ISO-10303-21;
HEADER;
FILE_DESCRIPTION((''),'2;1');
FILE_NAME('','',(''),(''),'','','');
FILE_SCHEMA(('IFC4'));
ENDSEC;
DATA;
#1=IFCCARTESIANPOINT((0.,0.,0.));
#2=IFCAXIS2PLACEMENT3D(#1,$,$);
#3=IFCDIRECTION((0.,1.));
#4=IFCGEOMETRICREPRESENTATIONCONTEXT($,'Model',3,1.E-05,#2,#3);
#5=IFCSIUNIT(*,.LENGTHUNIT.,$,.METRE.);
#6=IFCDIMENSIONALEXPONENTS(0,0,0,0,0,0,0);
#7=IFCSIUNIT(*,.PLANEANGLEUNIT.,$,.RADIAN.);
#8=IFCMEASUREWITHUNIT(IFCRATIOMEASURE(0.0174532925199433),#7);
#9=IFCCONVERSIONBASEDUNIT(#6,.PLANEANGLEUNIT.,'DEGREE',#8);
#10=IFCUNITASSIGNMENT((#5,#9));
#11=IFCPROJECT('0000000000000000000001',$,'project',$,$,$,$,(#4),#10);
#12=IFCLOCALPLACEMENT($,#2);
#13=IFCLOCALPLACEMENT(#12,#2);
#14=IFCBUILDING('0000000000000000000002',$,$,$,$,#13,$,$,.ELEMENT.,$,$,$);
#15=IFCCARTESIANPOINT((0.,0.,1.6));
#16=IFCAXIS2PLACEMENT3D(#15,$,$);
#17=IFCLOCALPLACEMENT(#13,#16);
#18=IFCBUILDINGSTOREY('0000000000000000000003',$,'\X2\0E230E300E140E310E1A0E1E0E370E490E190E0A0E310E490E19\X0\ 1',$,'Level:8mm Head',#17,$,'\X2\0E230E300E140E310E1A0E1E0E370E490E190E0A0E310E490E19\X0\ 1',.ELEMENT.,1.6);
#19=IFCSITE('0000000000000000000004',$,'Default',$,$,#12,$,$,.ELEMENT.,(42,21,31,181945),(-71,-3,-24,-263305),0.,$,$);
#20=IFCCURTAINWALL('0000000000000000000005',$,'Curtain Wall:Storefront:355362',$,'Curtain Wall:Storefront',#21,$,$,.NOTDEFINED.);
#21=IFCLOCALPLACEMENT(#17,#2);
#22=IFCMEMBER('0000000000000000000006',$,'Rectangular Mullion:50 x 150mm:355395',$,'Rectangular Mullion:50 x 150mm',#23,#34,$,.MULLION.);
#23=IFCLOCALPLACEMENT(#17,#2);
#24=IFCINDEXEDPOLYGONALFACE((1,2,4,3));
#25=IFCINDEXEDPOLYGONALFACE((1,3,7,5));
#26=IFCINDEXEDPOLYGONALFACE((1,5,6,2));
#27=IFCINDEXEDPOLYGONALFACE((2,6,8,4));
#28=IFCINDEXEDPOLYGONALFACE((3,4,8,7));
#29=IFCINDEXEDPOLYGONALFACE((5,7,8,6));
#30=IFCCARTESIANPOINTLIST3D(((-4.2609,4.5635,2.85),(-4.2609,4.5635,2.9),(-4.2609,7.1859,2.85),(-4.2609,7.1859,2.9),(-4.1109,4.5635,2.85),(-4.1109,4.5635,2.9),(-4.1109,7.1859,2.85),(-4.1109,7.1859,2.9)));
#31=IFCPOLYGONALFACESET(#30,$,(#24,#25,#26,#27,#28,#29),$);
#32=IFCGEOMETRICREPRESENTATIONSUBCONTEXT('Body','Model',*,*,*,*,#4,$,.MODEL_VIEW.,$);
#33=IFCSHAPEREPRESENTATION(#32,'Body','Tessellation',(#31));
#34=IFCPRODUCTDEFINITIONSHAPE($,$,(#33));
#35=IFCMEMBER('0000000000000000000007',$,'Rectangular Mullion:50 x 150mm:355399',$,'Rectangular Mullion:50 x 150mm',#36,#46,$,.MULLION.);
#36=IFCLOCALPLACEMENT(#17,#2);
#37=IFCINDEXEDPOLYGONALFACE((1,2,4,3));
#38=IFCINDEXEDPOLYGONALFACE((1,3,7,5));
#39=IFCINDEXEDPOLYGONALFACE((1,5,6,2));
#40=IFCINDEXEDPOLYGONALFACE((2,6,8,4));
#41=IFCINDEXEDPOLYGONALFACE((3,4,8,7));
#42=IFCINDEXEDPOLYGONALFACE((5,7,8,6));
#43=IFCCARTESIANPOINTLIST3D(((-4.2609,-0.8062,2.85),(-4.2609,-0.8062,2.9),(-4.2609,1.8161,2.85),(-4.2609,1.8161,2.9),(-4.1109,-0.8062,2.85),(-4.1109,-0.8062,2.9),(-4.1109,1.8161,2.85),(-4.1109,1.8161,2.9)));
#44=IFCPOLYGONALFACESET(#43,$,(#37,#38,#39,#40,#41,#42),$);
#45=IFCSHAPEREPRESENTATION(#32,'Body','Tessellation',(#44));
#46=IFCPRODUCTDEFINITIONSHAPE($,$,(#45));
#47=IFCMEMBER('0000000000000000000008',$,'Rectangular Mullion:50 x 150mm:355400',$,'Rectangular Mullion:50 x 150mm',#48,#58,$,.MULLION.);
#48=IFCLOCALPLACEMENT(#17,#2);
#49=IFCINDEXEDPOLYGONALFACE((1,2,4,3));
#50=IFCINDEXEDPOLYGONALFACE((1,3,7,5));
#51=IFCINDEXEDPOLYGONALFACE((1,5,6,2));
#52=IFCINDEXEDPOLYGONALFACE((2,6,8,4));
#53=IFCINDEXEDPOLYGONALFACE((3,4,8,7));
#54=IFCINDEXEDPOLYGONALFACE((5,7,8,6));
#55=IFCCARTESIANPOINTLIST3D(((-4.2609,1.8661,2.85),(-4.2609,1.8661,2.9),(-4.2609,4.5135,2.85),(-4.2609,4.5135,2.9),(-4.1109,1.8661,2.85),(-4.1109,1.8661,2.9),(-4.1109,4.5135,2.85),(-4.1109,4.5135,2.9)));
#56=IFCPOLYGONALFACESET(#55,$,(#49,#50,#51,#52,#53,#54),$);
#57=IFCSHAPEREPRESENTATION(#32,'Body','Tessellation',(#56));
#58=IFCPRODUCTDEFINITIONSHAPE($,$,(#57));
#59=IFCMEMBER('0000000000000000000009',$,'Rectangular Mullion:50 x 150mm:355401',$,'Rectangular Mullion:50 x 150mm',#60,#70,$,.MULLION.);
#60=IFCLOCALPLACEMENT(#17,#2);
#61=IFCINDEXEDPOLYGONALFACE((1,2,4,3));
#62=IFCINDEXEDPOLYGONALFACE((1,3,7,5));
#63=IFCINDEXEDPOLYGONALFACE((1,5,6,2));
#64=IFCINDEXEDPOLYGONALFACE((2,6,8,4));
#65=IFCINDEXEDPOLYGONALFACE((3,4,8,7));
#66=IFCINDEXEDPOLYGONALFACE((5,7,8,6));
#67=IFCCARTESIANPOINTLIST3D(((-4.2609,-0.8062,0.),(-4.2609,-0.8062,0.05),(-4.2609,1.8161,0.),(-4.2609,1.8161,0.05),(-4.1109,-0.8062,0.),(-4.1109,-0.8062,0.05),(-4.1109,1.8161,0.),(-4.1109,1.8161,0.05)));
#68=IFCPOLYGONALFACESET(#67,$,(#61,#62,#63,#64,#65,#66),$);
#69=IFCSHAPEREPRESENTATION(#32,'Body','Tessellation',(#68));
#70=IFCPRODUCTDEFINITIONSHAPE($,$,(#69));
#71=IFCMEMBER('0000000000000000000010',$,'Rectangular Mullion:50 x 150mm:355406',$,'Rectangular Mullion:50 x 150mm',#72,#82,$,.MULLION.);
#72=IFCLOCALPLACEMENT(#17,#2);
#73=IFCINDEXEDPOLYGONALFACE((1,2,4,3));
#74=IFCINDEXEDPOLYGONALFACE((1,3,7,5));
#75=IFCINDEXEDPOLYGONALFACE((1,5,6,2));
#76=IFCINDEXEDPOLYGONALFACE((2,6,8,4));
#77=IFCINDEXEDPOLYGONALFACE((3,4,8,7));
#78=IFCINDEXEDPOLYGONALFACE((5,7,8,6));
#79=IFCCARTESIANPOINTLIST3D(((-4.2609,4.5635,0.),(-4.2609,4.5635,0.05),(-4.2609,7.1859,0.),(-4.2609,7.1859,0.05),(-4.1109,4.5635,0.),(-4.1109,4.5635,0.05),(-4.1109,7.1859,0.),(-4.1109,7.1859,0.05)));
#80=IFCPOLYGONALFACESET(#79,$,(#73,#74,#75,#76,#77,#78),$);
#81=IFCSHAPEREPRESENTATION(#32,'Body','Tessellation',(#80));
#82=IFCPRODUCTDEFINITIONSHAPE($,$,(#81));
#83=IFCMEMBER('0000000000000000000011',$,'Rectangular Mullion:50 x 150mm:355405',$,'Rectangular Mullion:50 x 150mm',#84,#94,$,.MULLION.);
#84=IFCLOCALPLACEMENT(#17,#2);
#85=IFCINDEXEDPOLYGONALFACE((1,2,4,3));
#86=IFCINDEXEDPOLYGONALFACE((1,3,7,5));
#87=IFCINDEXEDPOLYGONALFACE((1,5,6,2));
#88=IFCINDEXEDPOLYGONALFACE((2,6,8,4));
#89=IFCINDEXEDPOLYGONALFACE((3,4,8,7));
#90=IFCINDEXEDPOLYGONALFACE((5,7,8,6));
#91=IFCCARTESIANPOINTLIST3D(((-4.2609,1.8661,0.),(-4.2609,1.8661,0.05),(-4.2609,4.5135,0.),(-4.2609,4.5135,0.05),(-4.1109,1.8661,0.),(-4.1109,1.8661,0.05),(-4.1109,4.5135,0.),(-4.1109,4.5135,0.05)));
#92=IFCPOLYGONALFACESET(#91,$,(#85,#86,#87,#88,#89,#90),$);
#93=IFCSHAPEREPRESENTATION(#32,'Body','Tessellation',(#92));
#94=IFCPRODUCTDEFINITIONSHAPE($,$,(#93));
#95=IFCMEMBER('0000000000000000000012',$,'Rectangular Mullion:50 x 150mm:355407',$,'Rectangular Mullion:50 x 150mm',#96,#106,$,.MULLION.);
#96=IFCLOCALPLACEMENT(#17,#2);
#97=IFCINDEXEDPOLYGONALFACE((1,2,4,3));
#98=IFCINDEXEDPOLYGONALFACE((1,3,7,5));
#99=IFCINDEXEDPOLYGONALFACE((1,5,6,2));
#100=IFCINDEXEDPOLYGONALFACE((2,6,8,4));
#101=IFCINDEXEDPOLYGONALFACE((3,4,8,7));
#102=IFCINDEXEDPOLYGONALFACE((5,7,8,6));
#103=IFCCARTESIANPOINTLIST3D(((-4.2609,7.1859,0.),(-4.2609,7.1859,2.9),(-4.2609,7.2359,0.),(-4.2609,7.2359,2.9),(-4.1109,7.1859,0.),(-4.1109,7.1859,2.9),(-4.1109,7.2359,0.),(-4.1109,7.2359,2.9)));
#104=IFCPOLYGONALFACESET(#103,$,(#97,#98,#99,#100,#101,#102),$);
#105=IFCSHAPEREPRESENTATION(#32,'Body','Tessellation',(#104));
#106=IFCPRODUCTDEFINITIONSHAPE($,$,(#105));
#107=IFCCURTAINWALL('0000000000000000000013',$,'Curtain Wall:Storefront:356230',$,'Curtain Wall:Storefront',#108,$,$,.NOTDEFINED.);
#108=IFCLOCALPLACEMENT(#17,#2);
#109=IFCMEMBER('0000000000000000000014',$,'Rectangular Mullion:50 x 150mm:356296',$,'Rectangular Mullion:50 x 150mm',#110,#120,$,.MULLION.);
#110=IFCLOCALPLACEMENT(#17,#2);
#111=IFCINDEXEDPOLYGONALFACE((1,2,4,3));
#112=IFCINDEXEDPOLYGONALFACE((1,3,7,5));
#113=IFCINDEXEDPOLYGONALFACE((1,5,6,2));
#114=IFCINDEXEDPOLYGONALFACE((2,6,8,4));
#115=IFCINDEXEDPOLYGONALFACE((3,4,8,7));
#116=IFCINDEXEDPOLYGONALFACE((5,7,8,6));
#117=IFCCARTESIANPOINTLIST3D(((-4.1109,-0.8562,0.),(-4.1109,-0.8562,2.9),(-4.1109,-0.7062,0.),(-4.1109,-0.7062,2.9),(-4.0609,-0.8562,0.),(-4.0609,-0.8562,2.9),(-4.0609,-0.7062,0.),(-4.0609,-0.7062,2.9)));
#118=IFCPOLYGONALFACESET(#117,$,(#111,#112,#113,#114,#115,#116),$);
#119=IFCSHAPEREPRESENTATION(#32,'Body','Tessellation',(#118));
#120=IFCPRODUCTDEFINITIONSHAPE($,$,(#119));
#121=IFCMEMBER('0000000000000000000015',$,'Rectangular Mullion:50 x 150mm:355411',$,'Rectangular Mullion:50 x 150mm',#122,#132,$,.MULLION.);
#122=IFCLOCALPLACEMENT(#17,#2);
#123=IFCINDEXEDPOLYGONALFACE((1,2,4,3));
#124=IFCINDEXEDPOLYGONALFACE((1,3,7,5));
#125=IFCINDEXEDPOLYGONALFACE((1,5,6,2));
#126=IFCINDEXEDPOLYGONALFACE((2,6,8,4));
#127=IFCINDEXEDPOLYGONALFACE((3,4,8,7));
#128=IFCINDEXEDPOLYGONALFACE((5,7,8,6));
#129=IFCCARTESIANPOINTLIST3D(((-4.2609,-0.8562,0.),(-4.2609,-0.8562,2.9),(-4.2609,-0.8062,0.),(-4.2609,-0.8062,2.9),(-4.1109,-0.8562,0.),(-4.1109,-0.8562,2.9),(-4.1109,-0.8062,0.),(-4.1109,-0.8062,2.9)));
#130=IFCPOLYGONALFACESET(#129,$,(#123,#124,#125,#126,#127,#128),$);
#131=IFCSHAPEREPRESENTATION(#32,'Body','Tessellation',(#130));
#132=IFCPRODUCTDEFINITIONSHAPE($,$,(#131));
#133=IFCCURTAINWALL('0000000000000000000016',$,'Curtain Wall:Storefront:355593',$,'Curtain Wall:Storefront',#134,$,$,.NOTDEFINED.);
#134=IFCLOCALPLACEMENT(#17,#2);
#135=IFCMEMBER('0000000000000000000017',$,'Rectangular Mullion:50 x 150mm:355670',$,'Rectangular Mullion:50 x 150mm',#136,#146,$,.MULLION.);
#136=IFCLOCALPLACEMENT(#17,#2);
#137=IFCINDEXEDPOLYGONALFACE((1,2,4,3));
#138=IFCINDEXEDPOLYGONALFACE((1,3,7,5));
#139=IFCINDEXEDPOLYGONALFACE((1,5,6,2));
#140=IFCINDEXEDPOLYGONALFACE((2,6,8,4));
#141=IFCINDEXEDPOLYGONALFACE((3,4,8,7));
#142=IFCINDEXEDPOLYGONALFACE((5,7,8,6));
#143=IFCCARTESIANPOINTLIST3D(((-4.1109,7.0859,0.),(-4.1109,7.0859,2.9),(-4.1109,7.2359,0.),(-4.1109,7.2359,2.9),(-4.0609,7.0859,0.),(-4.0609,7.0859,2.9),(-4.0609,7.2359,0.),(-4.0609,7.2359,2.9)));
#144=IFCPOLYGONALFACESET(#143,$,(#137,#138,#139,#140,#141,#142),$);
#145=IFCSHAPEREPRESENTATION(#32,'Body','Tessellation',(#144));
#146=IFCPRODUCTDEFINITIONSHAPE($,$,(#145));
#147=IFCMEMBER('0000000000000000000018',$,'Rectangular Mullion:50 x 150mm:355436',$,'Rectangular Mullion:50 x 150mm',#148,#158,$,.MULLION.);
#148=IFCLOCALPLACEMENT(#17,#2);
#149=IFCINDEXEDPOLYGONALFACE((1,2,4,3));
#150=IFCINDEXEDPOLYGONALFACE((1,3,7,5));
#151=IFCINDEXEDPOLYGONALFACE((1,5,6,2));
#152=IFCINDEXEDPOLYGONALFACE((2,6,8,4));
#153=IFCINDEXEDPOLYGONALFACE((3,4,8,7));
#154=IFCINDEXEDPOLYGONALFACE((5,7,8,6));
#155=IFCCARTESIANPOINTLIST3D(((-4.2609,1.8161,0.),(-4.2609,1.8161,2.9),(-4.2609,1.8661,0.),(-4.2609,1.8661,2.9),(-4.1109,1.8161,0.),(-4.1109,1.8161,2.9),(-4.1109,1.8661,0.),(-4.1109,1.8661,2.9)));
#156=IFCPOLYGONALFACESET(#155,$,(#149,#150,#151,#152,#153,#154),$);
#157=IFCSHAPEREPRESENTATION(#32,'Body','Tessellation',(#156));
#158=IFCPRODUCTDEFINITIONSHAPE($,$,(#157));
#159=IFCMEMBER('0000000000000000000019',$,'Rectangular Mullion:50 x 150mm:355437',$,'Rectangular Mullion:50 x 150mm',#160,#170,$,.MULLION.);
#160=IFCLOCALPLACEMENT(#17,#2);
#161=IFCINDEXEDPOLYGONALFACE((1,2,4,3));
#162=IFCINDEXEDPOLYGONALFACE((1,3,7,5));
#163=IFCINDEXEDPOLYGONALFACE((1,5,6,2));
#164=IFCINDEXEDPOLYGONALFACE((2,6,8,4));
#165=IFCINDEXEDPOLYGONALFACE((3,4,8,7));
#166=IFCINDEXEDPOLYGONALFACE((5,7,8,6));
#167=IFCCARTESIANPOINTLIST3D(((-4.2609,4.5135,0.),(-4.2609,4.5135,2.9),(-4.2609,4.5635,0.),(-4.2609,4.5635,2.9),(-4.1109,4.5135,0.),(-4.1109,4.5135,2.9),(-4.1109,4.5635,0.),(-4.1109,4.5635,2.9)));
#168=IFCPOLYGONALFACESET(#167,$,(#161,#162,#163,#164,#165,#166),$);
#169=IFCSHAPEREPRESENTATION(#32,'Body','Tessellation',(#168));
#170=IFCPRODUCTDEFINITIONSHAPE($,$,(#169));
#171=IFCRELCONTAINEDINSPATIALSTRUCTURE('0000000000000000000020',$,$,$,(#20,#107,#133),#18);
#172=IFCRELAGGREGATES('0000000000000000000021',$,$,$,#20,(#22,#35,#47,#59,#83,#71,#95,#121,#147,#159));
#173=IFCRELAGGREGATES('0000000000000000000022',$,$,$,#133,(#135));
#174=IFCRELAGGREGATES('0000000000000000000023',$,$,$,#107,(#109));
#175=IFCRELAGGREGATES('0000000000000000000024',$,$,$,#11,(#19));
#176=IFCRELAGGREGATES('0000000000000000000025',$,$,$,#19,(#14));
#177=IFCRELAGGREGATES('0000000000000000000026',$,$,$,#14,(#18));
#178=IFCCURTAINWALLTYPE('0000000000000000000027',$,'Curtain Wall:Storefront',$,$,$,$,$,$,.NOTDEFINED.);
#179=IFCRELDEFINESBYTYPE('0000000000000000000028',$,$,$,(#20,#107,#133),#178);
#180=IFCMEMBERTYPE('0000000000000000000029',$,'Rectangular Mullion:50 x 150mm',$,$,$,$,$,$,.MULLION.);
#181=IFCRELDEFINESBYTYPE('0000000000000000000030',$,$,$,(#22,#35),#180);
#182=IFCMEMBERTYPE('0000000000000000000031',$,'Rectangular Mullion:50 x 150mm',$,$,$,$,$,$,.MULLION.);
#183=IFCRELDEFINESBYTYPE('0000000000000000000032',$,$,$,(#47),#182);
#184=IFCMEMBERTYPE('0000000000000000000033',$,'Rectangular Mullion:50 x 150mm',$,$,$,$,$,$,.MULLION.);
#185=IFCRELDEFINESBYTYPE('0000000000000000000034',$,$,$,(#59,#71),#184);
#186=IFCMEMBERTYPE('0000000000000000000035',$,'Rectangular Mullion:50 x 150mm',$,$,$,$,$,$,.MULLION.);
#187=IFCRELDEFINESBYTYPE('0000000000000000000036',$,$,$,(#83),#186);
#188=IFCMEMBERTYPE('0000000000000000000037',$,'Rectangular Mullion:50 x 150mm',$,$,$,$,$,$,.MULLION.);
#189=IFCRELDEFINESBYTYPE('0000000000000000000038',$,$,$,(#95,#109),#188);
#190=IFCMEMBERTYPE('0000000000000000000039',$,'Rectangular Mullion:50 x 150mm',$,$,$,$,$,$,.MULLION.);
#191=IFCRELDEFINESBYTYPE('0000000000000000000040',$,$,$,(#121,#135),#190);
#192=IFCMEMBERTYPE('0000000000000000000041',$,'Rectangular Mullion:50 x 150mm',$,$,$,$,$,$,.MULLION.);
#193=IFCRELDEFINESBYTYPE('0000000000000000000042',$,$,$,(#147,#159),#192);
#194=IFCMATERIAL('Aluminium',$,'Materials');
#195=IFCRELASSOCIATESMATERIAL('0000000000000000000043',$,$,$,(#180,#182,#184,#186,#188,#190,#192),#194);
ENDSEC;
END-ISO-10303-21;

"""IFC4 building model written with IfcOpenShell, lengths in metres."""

from ifc_helpers import new_model, entity, si_unit, converted_unit, direction, frame, origin, place, context, subcontext, project, spatial, indexed_curve, outline, extrude, source, transform, mapped, material, type_object, type_shapes, element, aggregate, save


model = new_model("IFC4")

# Units and contexts
model_context = context("Model", 3, precision=1e-05, world=origin(), true_north=direction((0.0, 1.0)))
body_context = subcontext(model_context, "Body", "Model", "MODEL_VIEW")
ifc_project = project(units=[si_unit("LENGTHUNIT", "METRE"), converted_unit("PLANEANGLEUNIT", "DEGREE", entity("IfcRatioMeasure", 0.0174532925199433), si_unit("PLANEANGLEUNIT", "RADIAN"), dimensions=[0, 0, 0, 0, 0, 0, 0])], contexts=[model_context])

# Site, building, storey
site_placement = place(None, origin())
site = spatial("IfcSite", under=ifc_project, at=site_placement, Name="Default", CompositionType="ELEMENT", RefLatitude=(42, 21, 31, 181945), RefLongitude=(-71, -3, -24, -263305), RefElevation=0.0)
building_placement = place(site_placement, origin())
building = spatial("IfcBuilding", under=site, at=building_placement, CompositionType="ELEMENT")
storey_placement = place(building_placement, frame((0.0, 0.0, 1.6)))
storey = spatial("IfcBuildingStorey", under=building, at=storey_placement, Name="ระดับพื้นชั้น 1", ObjectType="Level:8mm Head", LongName="ระดับพื้นชั้น 1", CompositionType="ELEMENT", Elevation=1.6)

# Curtain wall, members
curtain_wall_type = type_object("IfcCurtainWallType", Name="Curtain Wall:Storefront", PredefinedType="NOTDEFINED")
curtain_wall_1_placement = place(storey_placement, frame((0.0, 0.0, -1.6)))
curtain_wall_1 = element("IfcCurtainWall", 1, at=curtain_wall_1_placement, inside=storey, type_object=curtain_wall_type, Name="Curtain Wall:Storefront:355362", ObjectType="Curtain Wall:Storefront", PredefinedType="NOTDEFINED")
ifc_material_1 = material(Name="Aluminium", Category="Materials")
member_type_1 = type_object("IfcMemberType", Name="Rectangular Mullion:50 x 150mm", PredefinedType="MULLION", material=ifc_material_1)
shared_shape_1 = source(origin(), body_context, "Body", "SweptSolid", [
    extrude(outline(indexed_curve([(-0.075, -0.025), (0.075, -0.025), (0.075, 0.025), (-0.075, 0.025), (-0.075, -0.025)], self_intersect=False)), frame((-0.025, 0.0, -2.6224), z_axis=(0.0, 0.0, 1.0), x_axis=(0.0, -1.0, 0.0)), (0.0, 0.0, 1.0), 2.6224),
])
type_shapes(member_type_1, [shared_shape_1])
member_1_placement = place(curtain_wall_1_placement, frame((-4.1859, 7.1859, 4.5), z_axis=(0.0, 1.0, 0.0), x_axis=(0.0, 0.0, 1.0)))
member_1 = element("IfcMember", 2, at=member_1_placement, type_object=member_type_1, Name="Rectangular Mullion:50 x 150mm:355395", ObjectType="Rectangular Mullion:50 x 150mm", PredefinedType="MULLION", context=body_context, shape_type="MappedRepresentation", body=[
    mapped(shared_shape_1, transform((0.0, 0.0, 0.0), scale=1.0)),
])
member_2_placement = place(curtain_wall_1_placement, frame((-4.1859, 1.8161, 4.5), z_axis=(0.0, 1.0, 0.0), x_axis=(0.0, 0.0, 1.0)))
member_2 = element("IfcMember", 3, at=member_2_placement, type_object=member_type_1, Name="Rectangular Mullion:50 x 150mm:355399", ObjectType="Rectangular Mullion:50 x 150mm", PredefinedType="MULLION", context=body_context, shape_type="MappedRepresentation", body=[
    mapped(shared_shape_1, transform((0.0, 0.0, 0.0), scale=1.0)),
])
member_type_2 = type_object("IfcMemberType", Name="Rectangular Mullion:50 x 150mm", PredefinedType="MULLION", material=ifc_material_1)
shared_shape_2 = source(origin(), body_context, "Body", "SweptSolid", [
    extrude(outline(indexed_curve([(-0.075, -0.025), (0.075, -0.025), (0.075, 0.025), (-0.075, 0.025), (-0.075, -0.025)], self_intersect=False)), frame((-0.025, 0.0, -2.6474), z_axis=(0.0, 0.0, 1.0), x_axis=(0.0, -1.0, 0.0)), (0.0, 0.0, 1.0), 2.6474),
])
type_shapes(member_type_2, [shared_shape_2])
member_3_placement = place(curtain_wall_1_placement, frame((-4.1859, 4.5135, 4.5), z_axis=(0.0, 1.0, 0.0), x_axis=(0.0, 0.0, 1.0)))
member_3 = element("IfcMember", 4, at=member_3_placement, type_object=member_type_2, Name="Rectangular Mullion:50 x 150mm:355400", ObjectType="Rectangular Mullion:50 x 150mm", PredefinedType="MULLION", context=body_context, shape_type="MappedRepresentation", body=[
    mapped(shared_shape_2, transform((0.0, 0.0, 0.0), scale=1.0)),
])
member_type_3 = type_object("IfcMemberType", Name="Rectangular Mullion:50 x 150mm", PredefinedType="MULLION", material=ifc_material_1)
shared_shape_3 = source(origin(), body_context, "Body", "SweptSolid", [
    extrude(outline(indexed_curve([(-0.075, -0.025), (0.075, -0.025), (0.075, 0.025), (-0.075, 0.025), (-0.075, -0.025)], self_intersect=False)), frame((-0.025, 0.0, -2.6224), z_axis=(0.0, 0.0, 1.0), x_axis=(0.0, -1.0, 0.0)), (0.0, 0.0, 1.0), 2.6224),
])
type_shapes(member_type_3, [shared_shape_3])
member_4_placement = place(curtain_wall_1_placement, frame((-4.1859, -0.8062, 1.6), z_axis=(0.0, -1.0, 0.0), x_axis=(0.0, 0.0, -1.0)))
member_4 = element("IfcMember", 5, at=member_4_placement, type_object=member_type_3, Name="Rectangular Mullion:50 x 150mm:355401", ObjectType="Rectangular Mullion:50 x 150mm", PredefinedType="MULLION", context=body_context, shape_type="MappedRepresentation", body=[
    mapped(shared_shape_3, transform((0.0, 0.0, 0.0), scale=1.0)),
])
member_5_placement = place(curtain_wall_1_placement, frame((-4.1859, 4.5635, 1.6), z_axis=(0.0, -1.0, 0.0), x_axis=(0.0, 0.0, -1.0)))
member_5 = element("IfcMember", 6, at=member_5_placement, type_object=member_type_3, Name="Rectangular Mullion:50 x 150mm:355406", ObjectType="Rectangular Mullion:50 x 150mm", PredefinedType="MULLION", context=body_context, shape_type="MappedRepresentation", body=[
    mapped(shared_shape_3, transform((0.0, 0.0, 0.0), scale=1.0)),
])
member_type_4 = type_object("IfcMemberType", Name="Rectangular Mullion:50 x 150mm", PredefinedType="MULLION", material=ifc_material_1)
shared_shape_4 = source(origin(), body_context, "Body", "SweptSolid", [
    extrude(outline(indexed_curve([(-0.075, -0.025), (0.075, -0.025), (0.075, 0.025), (-0.075, 0.025), (-0.075, -0.025)], self_intersect=False)), frame((-0.025, 0.0, -2.6474), z_axis=(0.0, 0.0, 1.0), x_axis=(0.0, -1.0, 0.0)), (0.0, 0.0, 1.0), 2.6474),
])
type_shapes(member_type_4, [shared_shape_4])
member_6_placement = place(curtain_wall_1_placement, frame((-4.1859, 1.8661, 1.6), z_axis=(0.0, -1.0, 0.0), x_axis=(0.0, 0.0, -1.0)))
member_6 = element("IfcMember", 7, at=member_6_placement, type_object=member_type_4, Name="Rectangular Mullion:50 x 150mm:355405", ObjectType="Rectangular Mullion:50 x 150mm", PredefinedType="MULLION", context=body_context, shape_type="MappedRepresentation", body=[
    mapped(shared_shape_4, transform((0.0, 0.0, 0.0), scale=1.0)),
])
member_type_5 = type_object("IfcMemberType", Name="Rectangular Mullion:50 x 150mm", PredefinedType="MULLION", material=ifc_material_1)
shared_shape_5 = source(origin(), body_context, "Body", "SweptSolid", [
    extrude(outline(indexed_curve([(-0.075, -0.025), (0.075, -0.025), (0.075, 0.025), (-0.075, 0.025), (-0.075, -0.025)], self_intersect=False)), frame((-0.025, 0.0, -2.9), z_axis=(0.0, 0.0, 1.0), x_axis=(0.0, -1.0, 0.0)), (0.0, 0.0, 1.0), 2.9),
])
type_shapes(member_type_5, [shared_shape_5])
member_7_placement = place(curtain_wall_1_placement, frame((-4.1859, 7.2359, 1.6), z_axis=(0.0, 0.0, -1.0), x_axis=(0.0, 1.0, 0.0)))
member_7 = element("IfcMember", 8, at=member_7_placement, type_object=member_type_5, Name="Rectangular Mullion:50 x 150mm:355407", ObjectType="Rectangular Mullion:50 x 150mm", PredefinedType="MULLION", context=body_context, shape_type="MappedRepresentation", body=[
    mapped(shared_shape_5, transform((0.0, 0.0, 0.0), scale=1.0)),
])

# Curtain wall, member
curtain_wall_2_placement = place(storey_placement, frame((0.0, 0.0, -1.6)))
curtain_wall_2 = element("IfcCurtainWall", 9, at=curtain_wall_2_placement, inside=storey, type_object=curtain_wall_type, Name="Curtain Wall:Storefront:356230", ObjectType="Curtain Wall:Storefront", PredefinedType="NOTDEFINED")
member_8_placement = place(curtain_wall_2_placement, frame((-4.1109, -0.7812, 1.6), z_axis=(0.0, 0.0, -1.0), x_axis=(-1.0, 0.0, 0.0)))
member_8 = element("IfcMember", 10, at=member_8_placement, type_object=member_type_5, Name="Rectangular Mullion:50 x 150mm:356296", ObjectType="Rectangular Mullion:50 x 150mm", PredefinedType="MULLION", context=body_context, shape_type="MappedRepresentation", body=[
    mapped(shared_shape_5, transform((0.0, 0.0, 0.0), scale=1.0)),
])

# Member
member_type_6 = type_object("IfcMemberType", Name="Rectangular Mullion:50 x 150mm", PredefinedType="MULLION", material=ifc_material_1)
shared_shape_6 = source(origin(), body_context, "Body", "SweptSolid", [
    extrude(outline(indexed_curve([(-0.075, -0.025), (0.075, -0.025), (0.075, 0.025), (-0.075, 0.025), (-0.075, -0.025)], self_intersect=False)), frame((-0.025, 0.0, -2.9), z_axis=(0.0, 0.0, 1.0), x_axis=(0.0, -1.0, 0.0)), (0.0, 0.0, 1.0), 2.9),
])
type_shapes(member_type_6, [shared_shape_6])
member_9_placement = place(curtain_wall_1_placement, frame((-4.1859, -0.8562, 4.5), z_axis=(0.0, 0.0, 1.0), x_axis=(0.0, -1.0, 0.0)))
member_9 = element("IfcMember", 11, at=member_9_placement, type_object=member_type_6, Name="Rectangular Mullion:50 x 150mm:355411", ObjectType="Rectangular Mullion:50 x 150mm", PredefinedType="MULLION", context=body_context, shape_type="MappedRepresentation", body=[
    mapped(shared_shape_6, transform((0.0, 0.0, 0.0), scale=1.0)),
])

# Curtain wall, member
curtain_wall_3_placement = place(storey_placement, frame((0.0, 0.0, -1.6)))
curtain_wall_3 = element("IfcCurtainWall", 12, at=curtain_wall_3_placement, inside=storey, type_object=curtain_wall_type, Name="Curtain Wall:Storefront:355593", ObjectType="Curtain Wall:Storefront", PredefinedType="NOTDEFINED")
member_10_placement = place(curtain_wall_3_placement, frame((-4.1109, 7.1609, 4.5), z_axis=(0.0, 0.0, 1.0), x_axis=(-1.0, 0.0, 0.0)))
member_10 = element("IfcMember", 13, at=member_10_placement, type_object=member_type_6, Name="Rectangular Mullion:50 x 150mm:355670", ObjectType="Rectangular Mullion:50 x 150mm", PredefinedType="MULLION", context=body_context, shape_type="MappedRepresentation", body=[
    mapped(shared_shape_6, transform((0.0, 0.0, 0.0), scale=1.0)),
])

# Members
member_type_7 = type_object("IfcMemberType", Name="Rectangular Mullion:50 x 150mm", PredefinedType="MULLION", material=ifc_material_1)
shared_shape_7 = source(origin(), body_context, "Body", "SweptSolid", [
    extrude(outline(indexed_curve([(-0.075, -0.025), (0.075, -0.025), (0.075, 0.025), (-0.075, 0.025), (-0.075, -0.025)], self_intersect=False)), frame((0.0, 0.0, -2.9), z_axis=(0.0, 0.0, 1.0), x_axis=(0.0, -1.0, 0.0)), (0.0, 0.0, 1.0), 2.9),
])
type_shapes(member_type_7, [shared_shape_7])
member_11_placement = place(curtain_wall_1_placement, frame((-4.1859, 1.8411, 1.6), z_axis=(0.0, 0.0, -1.0), x_axis=(0.0, 1.0, 0.0)))
member_11 = element("IfcMember", 14, at=member_11_placement, type_object=member_type_7, Name="Rectangular Mullion:50 x 150mm:355436", ObjectType="Rectangular Mullion:50 x 150mm", PredefinedType="MULLION", context=body_context, shape_type="MappedRepresentation", body=[
    mapped(shared_shape_7, transform((0.0, 0.0, 0.0), scale=1.0)),
])
member_12_placement = place(curtain_wall_1_placement, frame((-4.1859, 4.5385, 1.6), z_axis=(0.0, 0.0, -1.0), x_axis=(0.0, 1.0, 0.0)))
member_12 = element("IfcMember", 15, at=member_12_placement, type_object=member_type_7, Name="Rectangular Mullion:50 x 150mm:355437", ObjectType="Rectangular Mullion:50 x 150mm", PredefinedType="MULLION", context=body_context, shape_type="MappedRepresentation", body=[
    mapped(shared_shape_7, transform((0.0, 0.0, 0.0), scale=1.0)),
])

aggregate(curtain_wall_1, [member_1, member_2, member_3, member_4, member_6, member_5, member_7, member_9, member_11, member_12])
aggregate(curtain_wall_3, [member_10])
aggregate(curtain_wall_2, [member_8])

save(model, "model.ifc")
